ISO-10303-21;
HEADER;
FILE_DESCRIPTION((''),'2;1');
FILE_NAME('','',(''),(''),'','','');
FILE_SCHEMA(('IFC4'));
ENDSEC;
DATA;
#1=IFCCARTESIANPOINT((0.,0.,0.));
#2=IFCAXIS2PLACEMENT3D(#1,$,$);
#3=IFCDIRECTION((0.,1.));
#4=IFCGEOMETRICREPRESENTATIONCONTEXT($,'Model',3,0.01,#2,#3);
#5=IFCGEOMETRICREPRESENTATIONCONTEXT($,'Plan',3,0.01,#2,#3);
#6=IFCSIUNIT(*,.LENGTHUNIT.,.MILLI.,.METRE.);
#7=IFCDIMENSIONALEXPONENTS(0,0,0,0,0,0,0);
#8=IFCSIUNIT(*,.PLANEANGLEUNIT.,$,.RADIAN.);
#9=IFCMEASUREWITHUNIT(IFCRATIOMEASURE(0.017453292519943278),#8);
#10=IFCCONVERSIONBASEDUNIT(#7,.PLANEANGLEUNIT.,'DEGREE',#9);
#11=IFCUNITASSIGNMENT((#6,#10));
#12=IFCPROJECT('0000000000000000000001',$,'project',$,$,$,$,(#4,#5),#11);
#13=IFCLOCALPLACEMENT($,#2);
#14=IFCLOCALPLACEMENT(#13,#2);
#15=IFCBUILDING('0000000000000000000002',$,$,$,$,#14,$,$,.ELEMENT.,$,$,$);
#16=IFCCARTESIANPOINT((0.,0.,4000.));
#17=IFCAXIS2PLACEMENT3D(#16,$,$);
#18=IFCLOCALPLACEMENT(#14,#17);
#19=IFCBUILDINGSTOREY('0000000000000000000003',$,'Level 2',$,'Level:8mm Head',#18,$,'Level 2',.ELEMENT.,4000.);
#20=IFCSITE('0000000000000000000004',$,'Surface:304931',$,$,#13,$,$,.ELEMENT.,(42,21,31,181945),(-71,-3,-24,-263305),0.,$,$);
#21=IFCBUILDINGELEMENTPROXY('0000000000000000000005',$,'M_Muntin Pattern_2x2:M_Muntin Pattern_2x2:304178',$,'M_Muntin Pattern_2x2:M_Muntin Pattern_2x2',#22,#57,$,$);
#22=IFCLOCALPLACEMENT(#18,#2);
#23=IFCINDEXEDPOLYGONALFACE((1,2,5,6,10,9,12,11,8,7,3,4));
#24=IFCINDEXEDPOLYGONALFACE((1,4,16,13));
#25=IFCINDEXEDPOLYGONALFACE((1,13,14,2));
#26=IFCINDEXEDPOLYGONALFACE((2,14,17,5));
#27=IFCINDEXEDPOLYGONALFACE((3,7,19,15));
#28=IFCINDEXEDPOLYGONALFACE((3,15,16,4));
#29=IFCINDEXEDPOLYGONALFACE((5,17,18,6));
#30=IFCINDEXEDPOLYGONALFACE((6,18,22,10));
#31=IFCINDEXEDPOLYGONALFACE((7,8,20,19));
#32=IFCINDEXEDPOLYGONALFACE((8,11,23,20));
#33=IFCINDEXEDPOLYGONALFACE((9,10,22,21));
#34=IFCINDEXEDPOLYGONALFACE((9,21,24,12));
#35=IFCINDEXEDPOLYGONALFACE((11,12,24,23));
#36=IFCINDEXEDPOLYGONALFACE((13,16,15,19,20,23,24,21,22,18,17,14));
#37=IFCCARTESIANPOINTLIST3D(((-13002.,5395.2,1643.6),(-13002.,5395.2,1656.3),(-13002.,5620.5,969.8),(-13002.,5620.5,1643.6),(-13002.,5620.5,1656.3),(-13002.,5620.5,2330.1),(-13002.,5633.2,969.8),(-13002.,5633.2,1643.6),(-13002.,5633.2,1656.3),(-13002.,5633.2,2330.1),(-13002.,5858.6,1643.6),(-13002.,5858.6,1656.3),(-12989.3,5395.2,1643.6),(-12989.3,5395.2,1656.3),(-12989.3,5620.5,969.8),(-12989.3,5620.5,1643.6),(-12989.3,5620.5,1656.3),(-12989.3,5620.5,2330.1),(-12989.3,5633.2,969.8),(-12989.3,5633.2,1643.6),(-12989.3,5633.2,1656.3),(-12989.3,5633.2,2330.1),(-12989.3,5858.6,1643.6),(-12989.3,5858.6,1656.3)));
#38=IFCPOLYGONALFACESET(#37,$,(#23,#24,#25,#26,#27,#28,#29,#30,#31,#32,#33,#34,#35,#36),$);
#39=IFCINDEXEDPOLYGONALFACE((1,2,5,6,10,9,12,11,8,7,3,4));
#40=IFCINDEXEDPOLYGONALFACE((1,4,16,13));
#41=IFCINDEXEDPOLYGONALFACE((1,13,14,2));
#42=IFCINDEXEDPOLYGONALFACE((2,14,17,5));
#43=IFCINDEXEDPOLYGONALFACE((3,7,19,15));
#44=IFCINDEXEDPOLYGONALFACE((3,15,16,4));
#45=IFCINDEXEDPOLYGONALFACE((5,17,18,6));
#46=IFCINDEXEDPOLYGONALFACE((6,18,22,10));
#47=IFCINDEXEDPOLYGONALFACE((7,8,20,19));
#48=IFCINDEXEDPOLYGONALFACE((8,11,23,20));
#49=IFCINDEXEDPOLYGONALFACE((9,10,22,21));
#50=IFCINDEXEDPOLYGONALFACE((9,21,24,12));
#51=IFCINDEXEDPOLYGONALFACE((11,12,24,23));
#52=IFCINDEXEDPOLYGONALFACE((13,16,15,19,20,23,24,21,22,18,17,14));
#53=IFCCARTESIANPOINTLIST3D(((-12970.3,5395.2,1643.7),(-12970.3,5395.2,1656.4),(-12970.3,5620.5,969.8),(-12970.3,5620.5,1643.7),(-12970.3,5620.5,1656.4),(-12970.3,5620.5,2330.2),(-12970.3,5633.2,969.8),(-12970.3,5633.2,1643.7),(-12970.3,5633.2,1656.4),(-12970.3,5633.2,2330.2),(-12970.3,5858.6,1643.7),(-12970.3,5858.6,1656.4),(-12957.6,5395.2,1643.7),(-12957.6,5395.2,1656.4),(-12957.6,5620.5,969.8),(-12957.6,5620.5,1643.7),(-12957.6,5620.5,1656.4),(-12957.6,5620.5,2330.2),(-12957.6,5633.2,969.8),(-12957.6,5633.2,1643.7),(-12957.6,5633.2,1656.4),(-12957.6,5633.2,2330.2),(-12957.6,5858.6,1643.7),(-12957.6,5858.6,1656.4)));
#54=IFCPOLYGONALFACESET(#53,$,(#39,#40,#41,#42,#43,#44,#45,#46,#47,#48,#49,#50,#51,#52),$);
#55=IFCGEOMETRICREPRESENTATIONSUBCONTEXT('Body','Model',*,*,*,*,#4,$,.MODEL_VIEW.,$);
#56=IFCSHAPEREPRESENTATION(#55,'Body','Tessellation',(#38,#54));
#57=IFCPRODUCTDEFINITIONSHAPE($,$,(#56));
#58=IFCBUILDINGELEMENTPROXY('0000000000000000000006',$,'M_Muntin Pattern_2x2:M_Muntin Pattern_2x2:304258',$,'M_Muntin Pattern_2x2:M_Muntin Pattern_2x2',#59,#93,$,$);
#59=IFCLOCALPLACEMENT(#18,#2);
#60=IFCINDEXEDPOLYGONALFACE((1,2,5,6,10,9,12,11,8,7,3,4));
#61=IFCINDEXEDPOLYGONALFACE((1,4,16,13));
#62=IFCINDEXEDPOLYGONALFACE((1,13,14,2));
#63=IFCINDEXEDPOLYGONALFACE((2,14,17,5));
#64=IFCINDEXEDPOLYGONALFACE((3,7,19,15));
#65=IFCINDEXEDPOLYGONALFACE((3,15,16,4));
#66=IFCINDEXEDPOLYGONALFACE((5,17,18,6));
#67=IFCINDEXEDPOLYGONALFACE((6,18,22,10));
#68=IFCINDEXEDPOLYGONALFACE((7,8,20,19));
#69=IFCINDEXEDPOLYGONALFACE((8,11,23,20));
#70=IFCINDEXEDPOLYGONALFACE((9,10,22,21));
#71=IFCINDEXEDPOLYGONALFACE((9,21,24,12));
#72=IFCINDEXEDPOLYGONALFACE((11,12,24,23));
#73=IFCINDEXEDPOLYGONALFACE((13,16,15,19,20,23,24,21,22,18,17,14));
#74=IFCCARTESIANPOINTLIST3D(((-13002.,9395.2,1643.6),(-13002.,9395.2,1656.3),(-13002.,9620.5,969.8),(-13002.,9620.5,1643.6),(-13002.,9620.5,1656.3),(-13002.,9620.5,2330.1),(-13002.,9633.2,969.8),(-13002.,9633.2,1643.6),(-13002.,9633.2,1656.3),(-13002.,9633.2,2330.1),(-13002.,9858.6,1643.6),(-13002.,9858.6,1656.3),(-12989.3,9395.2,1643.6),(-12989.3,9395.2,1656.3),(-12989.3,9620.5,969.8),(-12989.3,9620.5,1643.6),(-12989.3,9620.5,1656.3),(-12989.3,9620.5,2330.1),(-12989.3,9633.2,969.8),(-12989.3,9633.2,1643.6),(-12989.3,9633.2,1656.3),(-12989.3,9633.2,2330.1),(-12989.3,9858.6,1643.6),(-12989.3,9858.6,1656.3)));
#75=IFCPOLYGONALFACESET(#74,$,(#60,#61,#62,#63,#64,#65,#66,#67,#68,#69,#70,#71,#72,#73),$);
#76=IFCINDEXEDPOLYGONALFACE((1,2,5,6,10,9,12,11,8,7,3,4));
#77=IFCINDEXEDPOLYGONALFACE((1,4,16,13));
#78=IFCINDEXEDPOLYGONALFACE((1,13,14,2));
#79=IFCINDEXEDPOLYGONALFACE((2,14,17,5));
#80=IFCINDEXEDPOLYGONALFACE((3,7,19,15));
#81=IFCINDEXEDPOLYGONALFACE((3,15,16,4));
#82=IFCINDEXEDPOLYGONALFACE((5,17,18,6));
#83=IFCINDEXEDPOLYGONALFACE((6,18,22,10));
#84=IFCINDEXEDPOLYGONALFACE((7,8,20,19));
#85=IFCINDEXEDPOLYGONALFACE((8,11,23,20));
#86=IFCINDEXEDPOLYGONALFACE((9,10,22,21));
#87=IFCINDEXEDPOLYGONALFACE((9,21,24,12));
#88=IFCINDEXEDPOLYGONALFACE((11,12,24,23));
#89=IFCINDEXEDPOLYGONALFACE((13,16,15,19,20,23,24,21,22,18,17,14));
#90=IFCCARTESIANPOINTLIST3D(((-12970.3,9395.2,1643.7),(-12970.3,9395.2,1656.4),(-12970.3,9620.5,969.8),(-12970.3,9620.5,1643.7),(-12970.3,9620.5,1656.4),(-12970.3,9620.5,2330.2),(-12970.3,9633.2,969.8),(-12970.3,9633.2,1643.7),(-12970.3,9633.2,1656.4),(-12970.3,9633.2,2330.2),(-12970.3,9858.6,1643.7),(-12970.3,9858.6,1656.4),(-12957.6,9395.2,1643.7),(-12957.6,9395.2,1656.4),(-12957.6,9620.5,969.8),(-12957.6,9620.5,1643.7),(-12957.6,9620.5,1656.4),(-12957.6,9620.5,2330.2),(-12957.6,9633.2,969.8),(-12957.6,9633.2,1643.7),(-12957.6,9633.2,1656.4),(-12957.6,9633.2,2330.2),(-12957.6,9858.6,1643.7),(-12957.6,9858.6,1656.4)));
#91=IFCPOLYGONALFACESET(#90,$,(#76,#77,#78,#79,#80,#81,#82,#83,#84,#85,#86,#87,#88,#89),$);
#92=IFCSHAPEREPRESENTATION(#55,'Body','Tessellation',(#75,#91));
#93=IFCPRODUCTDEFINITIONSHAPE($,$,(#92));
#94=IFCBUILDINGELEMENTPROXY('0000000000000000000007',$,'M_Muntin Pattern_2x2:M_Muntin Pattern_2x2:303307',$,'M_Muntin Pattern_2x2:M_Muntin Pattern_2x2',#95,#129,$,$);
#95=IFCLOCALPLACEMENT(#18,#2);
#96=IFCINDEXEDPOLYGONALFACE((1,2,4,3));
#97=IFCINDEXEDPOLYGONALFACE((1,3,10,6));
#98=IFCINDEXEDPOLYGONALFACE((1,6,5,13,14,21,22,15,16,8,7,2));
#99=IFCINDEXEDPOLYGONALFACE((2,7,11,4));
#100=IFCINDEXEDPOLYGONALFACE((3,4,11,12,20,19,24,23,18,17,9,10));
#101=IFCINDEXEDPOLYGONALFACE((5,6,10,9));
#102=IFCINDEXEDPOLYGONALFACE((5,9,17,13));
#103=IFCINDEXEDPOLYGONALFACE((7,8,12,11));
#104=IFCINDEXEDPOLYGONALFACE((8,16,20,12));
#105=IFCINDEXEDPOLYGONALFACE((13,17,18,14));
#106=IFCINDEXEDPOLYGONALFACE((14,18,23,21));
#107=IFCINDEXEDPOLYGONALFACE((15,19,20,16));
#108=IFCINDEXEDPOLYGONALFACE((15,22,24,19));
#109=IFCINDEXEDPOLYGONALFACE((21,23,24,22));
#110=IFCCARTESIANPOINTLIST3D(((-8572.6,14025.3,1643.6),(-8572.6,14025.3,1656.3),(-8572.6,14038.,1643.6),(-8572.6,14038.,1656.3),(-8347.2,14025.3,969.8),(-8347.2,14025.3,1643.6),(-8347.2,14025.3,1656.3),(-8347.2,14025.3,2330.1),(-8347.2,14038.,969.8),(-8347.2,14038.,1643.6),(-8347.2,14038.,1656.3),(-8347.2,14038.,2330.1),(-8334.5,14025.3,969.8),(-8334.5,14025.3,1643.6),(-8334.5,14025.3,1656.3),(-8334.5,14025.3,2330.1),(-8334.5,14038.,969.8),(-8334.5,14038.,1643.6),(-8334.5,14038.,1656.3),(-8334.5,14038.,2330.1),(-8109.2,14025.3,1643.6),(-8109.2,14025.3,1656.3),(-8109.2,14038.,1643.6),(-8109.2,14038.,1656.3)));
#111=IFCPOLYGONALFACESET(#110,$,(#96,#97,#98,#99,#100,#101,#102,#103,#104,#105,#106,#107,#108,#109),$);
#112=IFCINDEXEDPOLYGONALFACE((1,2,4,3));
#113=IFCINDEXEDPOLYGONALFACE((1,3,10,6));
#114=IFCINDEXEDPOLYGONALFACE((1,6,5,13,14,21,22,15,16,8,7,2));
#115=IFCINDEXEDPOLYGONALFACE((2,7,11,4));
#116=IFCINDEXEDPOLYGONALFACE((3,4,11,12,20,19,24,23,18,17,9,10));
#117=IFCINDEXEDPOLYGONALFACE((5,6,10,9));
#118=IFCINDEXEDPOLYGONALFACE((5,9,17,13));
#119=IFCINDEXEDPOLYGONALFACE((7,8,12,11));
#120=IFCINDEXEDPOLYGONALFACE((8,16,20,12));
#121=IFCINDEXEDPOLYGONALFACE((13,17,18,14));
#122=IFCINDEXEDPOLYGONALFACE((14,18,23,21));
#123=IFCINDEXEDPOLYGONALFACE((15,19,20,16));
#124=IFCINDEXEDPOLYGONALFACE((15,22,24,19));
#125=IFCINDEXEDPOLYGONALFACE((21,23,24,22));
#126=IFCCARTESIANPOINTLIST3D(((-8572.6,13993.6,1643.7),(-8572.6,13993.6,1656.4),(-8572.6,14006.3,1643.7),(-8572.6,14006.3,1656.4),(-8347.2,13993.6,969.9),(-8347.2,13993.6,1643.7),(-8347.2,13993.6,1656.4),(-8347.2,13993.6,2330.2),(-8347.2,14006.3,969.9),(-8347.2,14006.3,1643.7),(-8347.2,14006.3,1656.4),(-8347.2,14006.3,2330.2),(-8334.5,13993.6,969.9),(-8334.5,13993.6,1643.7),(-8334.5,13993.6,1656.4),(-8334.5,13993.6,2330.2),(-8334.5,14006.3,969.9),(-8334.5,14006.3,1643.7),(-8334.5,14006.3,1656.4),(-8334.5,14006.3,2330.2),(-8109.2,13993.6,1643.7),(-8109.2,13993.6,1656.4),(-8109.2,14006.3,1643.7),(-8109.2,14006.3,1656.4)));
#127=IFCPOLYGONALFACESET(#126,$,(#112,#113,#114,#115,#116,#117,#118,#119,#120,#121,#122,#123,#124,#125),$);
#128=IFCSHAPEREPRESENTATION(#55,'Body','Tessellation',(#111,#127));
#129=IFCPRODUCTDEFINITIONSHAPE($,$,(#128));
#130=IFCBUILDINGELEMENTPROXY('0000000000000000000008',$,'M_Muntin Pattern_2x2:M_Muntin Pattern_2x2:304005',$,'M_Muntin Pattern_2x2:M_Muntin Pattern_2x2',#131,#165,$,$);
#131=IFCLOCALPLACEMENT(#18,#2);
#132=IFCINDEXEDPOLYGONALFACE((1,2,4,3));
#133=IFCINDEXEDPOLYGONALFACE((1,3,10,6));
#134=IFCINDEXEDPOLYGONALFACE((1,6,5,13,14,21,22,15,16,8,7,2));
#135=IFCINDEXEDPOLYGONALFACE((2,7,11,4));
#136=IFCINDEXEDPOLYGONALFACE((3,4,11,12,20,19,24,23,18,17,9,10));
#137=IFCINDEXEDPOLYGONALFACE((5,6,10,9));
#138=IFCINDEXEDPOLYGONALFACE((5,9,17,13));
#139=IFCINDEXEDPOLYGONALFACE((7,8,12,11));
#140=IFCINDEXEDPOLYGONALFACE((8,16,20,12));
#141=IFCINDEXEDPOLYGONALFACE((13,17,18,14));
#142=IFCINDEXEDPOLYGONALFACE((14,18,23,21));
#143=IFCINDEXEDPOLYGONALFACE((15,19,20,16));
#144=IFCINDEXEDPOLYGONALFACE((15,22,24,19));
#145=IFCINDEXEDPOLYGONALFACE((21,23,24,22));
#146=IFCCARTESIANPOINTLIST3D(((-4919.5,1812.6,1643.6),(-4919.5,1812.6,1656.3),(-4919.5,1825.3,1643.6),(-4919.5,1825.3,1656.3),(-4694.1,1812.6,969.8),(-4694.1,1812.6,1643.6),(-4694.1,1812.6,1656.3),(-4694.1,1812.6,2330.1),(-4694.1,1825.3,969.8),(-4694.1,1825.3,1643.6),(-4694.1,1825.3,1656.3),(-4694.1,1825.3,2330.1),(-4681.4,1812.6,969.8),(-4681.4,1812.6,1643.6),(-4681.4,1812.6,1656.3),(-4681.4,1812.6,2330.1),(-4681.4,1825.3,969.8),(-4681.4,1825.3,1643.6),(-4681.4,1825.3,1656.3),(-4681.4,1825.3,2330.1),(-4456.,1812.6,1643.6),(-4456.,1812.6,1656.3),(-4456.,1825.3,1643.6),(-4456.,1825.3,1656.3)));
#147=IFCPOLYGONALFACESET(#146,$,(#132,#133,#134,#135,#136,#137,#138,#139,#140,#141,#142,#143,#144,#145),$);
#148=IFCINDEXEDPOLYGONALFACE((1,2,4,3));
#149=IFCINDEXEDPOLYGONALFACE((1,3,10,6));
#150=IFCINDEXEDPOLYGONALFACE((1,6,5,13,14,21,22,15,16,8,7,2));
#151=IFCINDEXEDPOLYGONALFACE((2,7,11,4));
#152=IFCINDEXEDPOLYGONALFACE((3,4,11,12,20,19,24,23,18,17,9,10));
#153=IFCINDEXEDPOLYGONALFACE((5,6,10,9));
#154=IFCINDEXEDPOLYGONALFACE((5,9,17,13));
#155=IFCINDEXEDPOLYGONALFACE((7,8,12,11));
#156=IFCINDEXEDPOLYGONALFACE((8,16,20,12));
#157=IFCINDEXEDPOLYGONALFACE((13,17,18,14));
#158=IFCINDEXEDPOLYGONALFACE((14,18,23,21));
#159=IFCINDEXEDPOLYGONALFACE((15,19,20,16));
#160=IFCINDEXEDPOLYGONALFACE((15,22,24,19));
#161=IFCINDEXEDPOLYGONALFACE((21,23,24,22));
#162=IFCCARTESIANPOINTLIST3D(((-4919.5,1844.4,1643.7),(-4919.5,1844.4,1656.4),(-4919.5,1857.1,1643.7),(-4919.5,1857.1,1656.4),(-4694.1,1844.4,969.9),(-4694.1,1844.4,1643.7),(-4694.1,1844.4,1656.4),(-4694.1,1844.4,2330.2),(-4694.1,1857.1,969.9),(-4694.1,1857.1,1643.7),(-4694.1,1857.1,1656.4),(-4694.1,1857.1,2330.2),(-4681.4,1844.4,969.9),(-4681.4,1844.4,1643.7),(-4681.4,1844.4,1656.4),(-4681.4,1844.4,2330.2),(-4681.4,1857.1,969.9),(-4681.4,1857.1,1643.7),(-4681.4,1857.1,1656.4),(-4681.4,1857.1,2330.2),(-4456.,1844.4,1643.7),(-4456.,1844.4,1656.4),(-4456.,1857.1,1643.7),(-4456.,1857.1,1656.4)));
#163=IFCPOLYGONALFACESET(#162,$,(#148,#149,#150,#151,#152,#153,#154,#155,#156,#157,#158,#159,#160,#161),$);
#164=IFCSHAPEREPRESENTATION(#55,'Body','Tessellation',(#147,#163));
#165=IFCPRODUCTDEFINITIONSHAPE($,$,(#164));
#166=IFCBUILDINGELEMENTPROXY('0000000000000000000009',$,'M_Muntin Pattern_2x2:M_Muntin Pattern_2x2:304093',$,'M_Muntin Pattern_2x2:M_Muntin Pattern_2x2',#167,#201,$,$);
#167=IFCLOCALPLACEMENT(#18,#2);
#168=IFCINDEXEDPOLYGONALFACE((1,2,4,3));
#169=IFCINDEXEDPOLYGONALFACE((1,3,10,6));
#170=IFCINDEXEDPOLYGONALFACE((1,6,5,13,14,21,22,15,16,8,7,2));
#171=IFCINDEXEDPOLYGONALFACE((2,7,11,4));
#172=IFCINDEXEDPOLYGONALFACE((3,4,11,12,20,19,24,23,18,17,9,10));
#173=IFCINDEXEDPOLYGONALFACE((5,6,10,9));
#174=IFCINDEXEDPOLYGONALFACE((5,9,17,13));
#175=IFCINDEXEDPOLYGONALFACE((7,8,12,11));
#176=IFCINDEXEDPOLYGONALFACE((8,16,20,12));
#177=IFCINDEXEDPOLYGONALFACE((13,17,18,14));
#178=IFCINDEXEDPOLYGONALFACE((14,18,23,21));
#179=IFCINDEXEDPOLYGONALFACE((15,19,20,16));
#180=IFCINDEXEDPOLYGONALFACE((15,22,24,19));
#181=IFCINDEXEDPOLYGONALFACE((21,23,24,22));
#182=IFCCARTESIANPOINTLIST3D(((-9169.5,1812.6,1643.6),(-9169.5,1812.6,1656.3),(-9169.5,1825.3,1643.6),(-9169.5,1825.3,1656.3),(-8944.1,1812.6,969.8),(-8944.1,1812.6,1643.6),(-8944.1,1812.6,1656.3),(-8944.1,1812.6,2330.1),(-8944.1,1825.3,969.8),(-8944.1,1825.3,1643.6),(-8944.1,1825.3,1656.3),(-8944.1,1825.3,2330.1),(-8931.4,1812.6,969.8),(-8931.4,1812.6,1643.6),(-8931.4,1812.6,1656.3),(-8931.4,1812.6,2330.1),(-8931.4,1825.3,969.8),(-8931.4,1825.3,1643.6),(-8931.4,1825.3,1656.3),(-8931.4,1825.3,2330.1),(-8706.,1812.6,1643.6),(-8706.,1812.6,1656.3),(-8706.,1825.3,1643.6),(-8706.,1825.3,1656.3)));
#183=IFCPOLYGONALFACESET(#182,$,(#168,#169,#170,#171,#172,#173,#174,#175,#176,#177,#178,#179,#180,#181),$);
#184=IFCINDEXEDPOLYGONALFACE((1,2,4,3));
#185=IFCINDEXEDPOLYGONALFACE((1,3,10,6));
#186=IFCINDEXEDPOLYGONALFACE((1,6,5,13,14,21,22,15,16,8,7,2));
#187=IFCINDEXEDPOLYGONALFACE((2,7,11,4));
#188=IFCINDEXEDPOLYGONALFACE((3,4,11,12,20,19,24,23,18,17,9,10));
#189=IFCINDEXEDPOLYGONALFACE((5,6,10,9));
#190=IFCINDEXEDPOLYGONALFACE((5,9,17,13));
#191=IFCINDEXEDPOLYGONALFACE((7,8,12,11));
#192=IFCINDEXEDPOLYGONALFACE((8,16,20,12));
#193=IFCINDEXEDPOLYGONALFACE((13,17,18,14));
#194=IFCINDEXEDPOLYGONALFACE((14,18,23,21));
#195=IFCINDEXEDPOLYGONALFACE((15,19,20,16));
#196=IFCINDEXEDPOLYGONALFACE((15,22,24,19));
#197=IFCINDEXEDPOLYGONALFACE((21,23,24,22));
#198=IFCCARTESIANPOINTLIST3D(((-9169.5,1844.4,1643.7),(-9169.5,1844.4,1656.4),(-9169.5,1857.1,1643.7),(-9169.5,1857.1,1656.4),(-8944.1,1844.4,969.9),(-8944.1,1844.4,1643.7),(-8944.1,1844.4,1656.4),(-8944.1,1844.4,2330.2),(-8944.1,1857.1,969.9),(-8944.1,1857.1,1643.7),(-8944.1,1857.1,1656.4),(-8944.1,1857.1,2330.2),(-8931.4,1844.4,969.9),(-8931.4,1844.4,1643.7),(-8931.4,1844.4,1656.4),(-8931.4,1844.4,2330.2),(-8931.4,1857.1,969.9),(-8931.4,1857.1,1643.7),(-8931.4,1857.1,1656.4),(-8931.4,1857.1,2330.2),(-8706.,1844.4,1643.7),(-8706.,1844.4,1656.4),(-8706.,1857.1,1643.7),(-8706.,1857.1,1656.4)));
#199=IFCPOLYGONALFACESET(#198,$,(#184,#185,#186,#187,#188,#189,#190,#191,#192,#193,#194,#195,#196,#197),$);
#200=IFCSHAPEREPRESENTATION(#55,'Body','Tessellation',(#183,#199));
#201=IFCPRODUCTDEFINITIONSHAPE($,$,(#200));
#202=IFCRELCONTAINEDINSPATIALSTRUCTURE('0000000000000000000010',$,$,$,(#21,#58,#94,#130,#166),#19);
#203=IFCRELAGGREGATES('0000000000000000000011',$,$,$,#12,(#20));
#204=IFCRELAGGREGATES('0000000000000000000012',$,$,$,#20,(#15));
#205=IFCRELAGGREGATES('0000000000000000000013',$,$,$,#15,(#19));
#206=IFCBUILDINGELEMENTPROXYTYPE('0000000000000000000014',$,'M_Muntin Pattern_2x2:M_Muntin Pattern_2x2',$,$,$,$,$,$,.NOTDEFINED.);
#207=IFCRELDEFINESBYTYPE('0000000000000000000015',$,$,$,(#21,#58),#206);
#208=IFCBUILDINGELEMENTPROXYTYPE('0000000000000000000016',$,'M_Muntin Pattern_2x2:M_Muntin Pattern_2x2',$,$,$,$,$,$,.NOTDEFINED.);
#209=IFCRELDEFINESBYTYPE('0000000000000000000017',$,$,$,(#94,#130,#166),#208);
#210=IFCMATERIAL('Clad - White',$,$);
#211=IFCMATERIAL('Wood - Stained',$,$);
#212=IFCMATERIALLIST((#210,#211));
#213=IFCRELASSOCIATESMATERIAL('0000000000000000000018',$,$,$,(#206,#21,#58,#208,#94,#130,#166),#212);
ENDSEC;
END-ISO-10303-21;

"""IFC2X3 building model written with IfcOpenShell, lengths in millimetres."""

from ifc_helpers import new_model, entity, si_unit, converted_unit, direction, frame, origin, place, context, subcontext, project, spatial, polyline, outline, extrude, source, transform, mapped, material, material_list, type_object, type_shapes, element, save


model = new_model("IFC2X3")

# Units and contexts
model_context = context("Model", 3, precision=0.01, world=origin(), true_north=direction((0.0, 1.0)))
plan_context = context("Plan", 3, precision=0.01, world=origin(), true_north=direction((0.0, 1.0)))
body_context = subcontext(model_context, "Body", "Model", "MODEL_VIEW")
ifc_project = project(units=[si_unit("LENGTHUNIT", "METRE", prefix="MILLI"), converted_unit("PLANEANGLEUNIT", "DEGREE", entity("IfcRatioMeasure", 0.017453292519943278), si_unit("PLANEANGLEUNIT", "RADIAN"), dimensions=[0, 0, 0, 0, 0, 0, 0])], contexts=[model_context, plan_context])

# Site, building, storey
site_placement = place(None, origin())
site = spatial("IfcSite", under=ifc_project, at=site_placement, Name="Surface:304931", CompositionType="ELEMENT", RefLatitude=(42, 21, 31, 181945), RefLongitude=(-71, -3, -24, -263305), RefElevation=0.0)
building_placement = place(site_placement, origin())
building = spatial("IfcBuilding", under=site, at=building_placement, CompositionType="ELEMENT")
storey_placement = place(building_placement, frame((0.0, 0.0, 4000.0)))
storey = spatial("IfcBuildingStorey", under=building, at=storey_placement, Name="Level 2", ObjectType="Level:8mm Head", LongName="Level 2", CompositionType="ELEMENT", Elevation=4000.0)

# Building element proxies
ifc_material_1 = material(Name="Clad - White")
ifc_material_2 = material(Name="Wood - Stained")
ifc_material_list = material_list([ifc_material_1, ifc_material_2])
building_element_proxy_type_1 = type_object("IfcBuildingElementProxyType", Name="M_Muntin Pattern_2x2:M_Muntin Pattern_2x2", PredefinedType="NOTDEFINED", material=ifc_material_list)
shared_shape_1 = source(origin(), body_context, "Body", "SweptSolid", [
    extrude(outline(polyline([(6.4, -6.4), (680.1, -6.4), (680.1, 6.3), (6.4, 6.3), (6.4, 231.7), (-6.3, 231.7), (-6.3, 6.3), (-680.2, 6.3), (-680.2, -6.4), (-6.3, -6.4), (-6.3, -231.7), (6.4, -231.7), (6.4, -6.4)])), frame((0.0, 9.5, 680.1), z_axis=(0.0, 1.0, 0.0), x_axis=(0.0, 0.0, 1.0)), (0.0, 0.0, 1.0), 12.7),
    extrude(outline(polyline([(6.4, -6.4), (680.2, -6.4), (680.2, 6.3), (6.4, 6.3), (6.4, 231.7), (-6.3, 231.7), (-6.3, 6.3), (-680.2, 6.3), (-680.2, -6.4), (-6.3, -6.4), (-6.3, -231.7), (6.4, -231.7), (6.4, -6.4)])), frame((0.0, -22.2, 680.2), z_axis=(0.0, 1.0, 0.0), x_axis=(0.0, 0.0, 1.0)), (0.0, 0.0, 1.0), 12.7),
])
type_shapes(building_element_proxy_type_1, [shared_shape_1])
for number, where, z_axis, x_axis, name in (
    (1, (-12979.8, 5626.9, 969.8), (0.0, 0.0, 1.0), (0.0, 1.0, 0.0), "M_Muntin Pattern_2x2:M_Muntin Pattern_2x2:304178"),
    (2, (-12979.8, 9626.9, 969.8), (0.0, 0.0, 1.0), (0.0, 1.0, 0.0), "M_Muntin Pattern_2x2:M_Muntin Pattern_2x2:304258"),
):
    element("IfcBuildingElementProxy", number, at=place(storey_placement, frame(where, z_axis=z_axis, x_axis=x_axis)), inside=storey, type_object=building_element_proxy_type_1, material=ifc_material_list, Name=name, ObjectType="M_Muntin Pattern_2x2:M_Muntin Pattern_2x2", context=body_context, shape_type="MappedRepresentation", body=[
        mapped(shared_shape_1, transform((0.0, 0.0, 0.0), scale=1.0)),
    ])
building_element_proxy_type_2 = type_object("IfcBuildingElementProxyType", Name="M_Muntin Pattern_2x2:M_Muntin Pattern_2x2", PredefinedType="NOTDEFINED", material=ifc_material_list)
shared_shape_2 = source(origin(), body_context, "Body", "SweptSolid", [
    extrude(outline(polyline([(6.4, -6.4), (680.1, -6.4), (680.1, 6.3), (6.4, 6.3), (6.4, 231.7), (-6.3, 231.7), (-6.3, 6.3), (-680.2, 6.3), (-680.2, -6.4), (-6.3, -6.4), (-6.3, -231.7), (6.4, -231.7), (6.4, -6.4)])), frame((0.0, -22.2, 680.1), z_axis=(0.0, 1.0, 0.0), x_axis=(0.0, 0.0, 1.0)), (0.0, 0.0, 1.0), 12.7),
    extrude(outline(polyline([(6.4, -6.4), (680.2, -6.4), (680.2, 6.3), (6.4, 6.3), (6.4, 231.7), (-6.3, 231.7), (-6.3, 6.3), (-680.2, 6.3), (-680.2, -6.4), (-6.3, -6.4), (-6.3, -231.7), (6.4, -231.7), (6.4, -6.4)])), frame((0.0, 9.5, 680.2), z_axis=(0.0, 1.0, 0.0), x_axis=(0.0, 0.0, 1.0)), (0.0, 0.0, 1.0), 12.7),
])
type_shapes(building_element_proxy_type_2, [shared_shape_2])
proxy_placement = place(storey_placement, frame((-8340.9, 14015.8, 969.9), z_axis=(0.0, 0.0, 1.0), x_axis=(-1.0, 0.0, 0.0)))
element("IfcBuildingElementProxy", 3, at=proxy_placement, inside=storey, type_object=building_element_proxy_type_2, material=ifc_material_list, Name="M_Muntin Pattern_2x2:M_Muntin Pattern_2x2:303307", ObjectType="M_Muntin Pattern_2x2:M_Muntin Pattern_2x2", context=body_context, shape_type="MappedRepresentation", body=[
    mapped(shared_shape_2, transform((0.0, 0.0, 0.0), scale=1.0)),
])
for number, where, name in (
    (4, (-4687.7, 1834.8, 969.9), "M_Muntin Pattern_2x2:M_Muntin Pattern_2x2:304005"),
    (5, (-8937.7, 1834.8, 969.9), "M_Muntin Pattern_2x2:M_Muntin Pattern_2x2:304093"),
):
    element("IfcBuildingElementProxy", number, at=place(storey_placement, frame(where)), inside=storey, type_object=building_element_proxy_type_2, material=ifc_material_list, Name=name, ObjectType="M_Muntin Pattern_2x2:M_Muntin Pattern_2x2", context=body_context, shape_type="MappedRepresentation", body=[
        mapped(shared_shape_2, transform((0.0, 0.0, 0.0), scale=1.0)),
    ])

save(model, "model.ifc")
